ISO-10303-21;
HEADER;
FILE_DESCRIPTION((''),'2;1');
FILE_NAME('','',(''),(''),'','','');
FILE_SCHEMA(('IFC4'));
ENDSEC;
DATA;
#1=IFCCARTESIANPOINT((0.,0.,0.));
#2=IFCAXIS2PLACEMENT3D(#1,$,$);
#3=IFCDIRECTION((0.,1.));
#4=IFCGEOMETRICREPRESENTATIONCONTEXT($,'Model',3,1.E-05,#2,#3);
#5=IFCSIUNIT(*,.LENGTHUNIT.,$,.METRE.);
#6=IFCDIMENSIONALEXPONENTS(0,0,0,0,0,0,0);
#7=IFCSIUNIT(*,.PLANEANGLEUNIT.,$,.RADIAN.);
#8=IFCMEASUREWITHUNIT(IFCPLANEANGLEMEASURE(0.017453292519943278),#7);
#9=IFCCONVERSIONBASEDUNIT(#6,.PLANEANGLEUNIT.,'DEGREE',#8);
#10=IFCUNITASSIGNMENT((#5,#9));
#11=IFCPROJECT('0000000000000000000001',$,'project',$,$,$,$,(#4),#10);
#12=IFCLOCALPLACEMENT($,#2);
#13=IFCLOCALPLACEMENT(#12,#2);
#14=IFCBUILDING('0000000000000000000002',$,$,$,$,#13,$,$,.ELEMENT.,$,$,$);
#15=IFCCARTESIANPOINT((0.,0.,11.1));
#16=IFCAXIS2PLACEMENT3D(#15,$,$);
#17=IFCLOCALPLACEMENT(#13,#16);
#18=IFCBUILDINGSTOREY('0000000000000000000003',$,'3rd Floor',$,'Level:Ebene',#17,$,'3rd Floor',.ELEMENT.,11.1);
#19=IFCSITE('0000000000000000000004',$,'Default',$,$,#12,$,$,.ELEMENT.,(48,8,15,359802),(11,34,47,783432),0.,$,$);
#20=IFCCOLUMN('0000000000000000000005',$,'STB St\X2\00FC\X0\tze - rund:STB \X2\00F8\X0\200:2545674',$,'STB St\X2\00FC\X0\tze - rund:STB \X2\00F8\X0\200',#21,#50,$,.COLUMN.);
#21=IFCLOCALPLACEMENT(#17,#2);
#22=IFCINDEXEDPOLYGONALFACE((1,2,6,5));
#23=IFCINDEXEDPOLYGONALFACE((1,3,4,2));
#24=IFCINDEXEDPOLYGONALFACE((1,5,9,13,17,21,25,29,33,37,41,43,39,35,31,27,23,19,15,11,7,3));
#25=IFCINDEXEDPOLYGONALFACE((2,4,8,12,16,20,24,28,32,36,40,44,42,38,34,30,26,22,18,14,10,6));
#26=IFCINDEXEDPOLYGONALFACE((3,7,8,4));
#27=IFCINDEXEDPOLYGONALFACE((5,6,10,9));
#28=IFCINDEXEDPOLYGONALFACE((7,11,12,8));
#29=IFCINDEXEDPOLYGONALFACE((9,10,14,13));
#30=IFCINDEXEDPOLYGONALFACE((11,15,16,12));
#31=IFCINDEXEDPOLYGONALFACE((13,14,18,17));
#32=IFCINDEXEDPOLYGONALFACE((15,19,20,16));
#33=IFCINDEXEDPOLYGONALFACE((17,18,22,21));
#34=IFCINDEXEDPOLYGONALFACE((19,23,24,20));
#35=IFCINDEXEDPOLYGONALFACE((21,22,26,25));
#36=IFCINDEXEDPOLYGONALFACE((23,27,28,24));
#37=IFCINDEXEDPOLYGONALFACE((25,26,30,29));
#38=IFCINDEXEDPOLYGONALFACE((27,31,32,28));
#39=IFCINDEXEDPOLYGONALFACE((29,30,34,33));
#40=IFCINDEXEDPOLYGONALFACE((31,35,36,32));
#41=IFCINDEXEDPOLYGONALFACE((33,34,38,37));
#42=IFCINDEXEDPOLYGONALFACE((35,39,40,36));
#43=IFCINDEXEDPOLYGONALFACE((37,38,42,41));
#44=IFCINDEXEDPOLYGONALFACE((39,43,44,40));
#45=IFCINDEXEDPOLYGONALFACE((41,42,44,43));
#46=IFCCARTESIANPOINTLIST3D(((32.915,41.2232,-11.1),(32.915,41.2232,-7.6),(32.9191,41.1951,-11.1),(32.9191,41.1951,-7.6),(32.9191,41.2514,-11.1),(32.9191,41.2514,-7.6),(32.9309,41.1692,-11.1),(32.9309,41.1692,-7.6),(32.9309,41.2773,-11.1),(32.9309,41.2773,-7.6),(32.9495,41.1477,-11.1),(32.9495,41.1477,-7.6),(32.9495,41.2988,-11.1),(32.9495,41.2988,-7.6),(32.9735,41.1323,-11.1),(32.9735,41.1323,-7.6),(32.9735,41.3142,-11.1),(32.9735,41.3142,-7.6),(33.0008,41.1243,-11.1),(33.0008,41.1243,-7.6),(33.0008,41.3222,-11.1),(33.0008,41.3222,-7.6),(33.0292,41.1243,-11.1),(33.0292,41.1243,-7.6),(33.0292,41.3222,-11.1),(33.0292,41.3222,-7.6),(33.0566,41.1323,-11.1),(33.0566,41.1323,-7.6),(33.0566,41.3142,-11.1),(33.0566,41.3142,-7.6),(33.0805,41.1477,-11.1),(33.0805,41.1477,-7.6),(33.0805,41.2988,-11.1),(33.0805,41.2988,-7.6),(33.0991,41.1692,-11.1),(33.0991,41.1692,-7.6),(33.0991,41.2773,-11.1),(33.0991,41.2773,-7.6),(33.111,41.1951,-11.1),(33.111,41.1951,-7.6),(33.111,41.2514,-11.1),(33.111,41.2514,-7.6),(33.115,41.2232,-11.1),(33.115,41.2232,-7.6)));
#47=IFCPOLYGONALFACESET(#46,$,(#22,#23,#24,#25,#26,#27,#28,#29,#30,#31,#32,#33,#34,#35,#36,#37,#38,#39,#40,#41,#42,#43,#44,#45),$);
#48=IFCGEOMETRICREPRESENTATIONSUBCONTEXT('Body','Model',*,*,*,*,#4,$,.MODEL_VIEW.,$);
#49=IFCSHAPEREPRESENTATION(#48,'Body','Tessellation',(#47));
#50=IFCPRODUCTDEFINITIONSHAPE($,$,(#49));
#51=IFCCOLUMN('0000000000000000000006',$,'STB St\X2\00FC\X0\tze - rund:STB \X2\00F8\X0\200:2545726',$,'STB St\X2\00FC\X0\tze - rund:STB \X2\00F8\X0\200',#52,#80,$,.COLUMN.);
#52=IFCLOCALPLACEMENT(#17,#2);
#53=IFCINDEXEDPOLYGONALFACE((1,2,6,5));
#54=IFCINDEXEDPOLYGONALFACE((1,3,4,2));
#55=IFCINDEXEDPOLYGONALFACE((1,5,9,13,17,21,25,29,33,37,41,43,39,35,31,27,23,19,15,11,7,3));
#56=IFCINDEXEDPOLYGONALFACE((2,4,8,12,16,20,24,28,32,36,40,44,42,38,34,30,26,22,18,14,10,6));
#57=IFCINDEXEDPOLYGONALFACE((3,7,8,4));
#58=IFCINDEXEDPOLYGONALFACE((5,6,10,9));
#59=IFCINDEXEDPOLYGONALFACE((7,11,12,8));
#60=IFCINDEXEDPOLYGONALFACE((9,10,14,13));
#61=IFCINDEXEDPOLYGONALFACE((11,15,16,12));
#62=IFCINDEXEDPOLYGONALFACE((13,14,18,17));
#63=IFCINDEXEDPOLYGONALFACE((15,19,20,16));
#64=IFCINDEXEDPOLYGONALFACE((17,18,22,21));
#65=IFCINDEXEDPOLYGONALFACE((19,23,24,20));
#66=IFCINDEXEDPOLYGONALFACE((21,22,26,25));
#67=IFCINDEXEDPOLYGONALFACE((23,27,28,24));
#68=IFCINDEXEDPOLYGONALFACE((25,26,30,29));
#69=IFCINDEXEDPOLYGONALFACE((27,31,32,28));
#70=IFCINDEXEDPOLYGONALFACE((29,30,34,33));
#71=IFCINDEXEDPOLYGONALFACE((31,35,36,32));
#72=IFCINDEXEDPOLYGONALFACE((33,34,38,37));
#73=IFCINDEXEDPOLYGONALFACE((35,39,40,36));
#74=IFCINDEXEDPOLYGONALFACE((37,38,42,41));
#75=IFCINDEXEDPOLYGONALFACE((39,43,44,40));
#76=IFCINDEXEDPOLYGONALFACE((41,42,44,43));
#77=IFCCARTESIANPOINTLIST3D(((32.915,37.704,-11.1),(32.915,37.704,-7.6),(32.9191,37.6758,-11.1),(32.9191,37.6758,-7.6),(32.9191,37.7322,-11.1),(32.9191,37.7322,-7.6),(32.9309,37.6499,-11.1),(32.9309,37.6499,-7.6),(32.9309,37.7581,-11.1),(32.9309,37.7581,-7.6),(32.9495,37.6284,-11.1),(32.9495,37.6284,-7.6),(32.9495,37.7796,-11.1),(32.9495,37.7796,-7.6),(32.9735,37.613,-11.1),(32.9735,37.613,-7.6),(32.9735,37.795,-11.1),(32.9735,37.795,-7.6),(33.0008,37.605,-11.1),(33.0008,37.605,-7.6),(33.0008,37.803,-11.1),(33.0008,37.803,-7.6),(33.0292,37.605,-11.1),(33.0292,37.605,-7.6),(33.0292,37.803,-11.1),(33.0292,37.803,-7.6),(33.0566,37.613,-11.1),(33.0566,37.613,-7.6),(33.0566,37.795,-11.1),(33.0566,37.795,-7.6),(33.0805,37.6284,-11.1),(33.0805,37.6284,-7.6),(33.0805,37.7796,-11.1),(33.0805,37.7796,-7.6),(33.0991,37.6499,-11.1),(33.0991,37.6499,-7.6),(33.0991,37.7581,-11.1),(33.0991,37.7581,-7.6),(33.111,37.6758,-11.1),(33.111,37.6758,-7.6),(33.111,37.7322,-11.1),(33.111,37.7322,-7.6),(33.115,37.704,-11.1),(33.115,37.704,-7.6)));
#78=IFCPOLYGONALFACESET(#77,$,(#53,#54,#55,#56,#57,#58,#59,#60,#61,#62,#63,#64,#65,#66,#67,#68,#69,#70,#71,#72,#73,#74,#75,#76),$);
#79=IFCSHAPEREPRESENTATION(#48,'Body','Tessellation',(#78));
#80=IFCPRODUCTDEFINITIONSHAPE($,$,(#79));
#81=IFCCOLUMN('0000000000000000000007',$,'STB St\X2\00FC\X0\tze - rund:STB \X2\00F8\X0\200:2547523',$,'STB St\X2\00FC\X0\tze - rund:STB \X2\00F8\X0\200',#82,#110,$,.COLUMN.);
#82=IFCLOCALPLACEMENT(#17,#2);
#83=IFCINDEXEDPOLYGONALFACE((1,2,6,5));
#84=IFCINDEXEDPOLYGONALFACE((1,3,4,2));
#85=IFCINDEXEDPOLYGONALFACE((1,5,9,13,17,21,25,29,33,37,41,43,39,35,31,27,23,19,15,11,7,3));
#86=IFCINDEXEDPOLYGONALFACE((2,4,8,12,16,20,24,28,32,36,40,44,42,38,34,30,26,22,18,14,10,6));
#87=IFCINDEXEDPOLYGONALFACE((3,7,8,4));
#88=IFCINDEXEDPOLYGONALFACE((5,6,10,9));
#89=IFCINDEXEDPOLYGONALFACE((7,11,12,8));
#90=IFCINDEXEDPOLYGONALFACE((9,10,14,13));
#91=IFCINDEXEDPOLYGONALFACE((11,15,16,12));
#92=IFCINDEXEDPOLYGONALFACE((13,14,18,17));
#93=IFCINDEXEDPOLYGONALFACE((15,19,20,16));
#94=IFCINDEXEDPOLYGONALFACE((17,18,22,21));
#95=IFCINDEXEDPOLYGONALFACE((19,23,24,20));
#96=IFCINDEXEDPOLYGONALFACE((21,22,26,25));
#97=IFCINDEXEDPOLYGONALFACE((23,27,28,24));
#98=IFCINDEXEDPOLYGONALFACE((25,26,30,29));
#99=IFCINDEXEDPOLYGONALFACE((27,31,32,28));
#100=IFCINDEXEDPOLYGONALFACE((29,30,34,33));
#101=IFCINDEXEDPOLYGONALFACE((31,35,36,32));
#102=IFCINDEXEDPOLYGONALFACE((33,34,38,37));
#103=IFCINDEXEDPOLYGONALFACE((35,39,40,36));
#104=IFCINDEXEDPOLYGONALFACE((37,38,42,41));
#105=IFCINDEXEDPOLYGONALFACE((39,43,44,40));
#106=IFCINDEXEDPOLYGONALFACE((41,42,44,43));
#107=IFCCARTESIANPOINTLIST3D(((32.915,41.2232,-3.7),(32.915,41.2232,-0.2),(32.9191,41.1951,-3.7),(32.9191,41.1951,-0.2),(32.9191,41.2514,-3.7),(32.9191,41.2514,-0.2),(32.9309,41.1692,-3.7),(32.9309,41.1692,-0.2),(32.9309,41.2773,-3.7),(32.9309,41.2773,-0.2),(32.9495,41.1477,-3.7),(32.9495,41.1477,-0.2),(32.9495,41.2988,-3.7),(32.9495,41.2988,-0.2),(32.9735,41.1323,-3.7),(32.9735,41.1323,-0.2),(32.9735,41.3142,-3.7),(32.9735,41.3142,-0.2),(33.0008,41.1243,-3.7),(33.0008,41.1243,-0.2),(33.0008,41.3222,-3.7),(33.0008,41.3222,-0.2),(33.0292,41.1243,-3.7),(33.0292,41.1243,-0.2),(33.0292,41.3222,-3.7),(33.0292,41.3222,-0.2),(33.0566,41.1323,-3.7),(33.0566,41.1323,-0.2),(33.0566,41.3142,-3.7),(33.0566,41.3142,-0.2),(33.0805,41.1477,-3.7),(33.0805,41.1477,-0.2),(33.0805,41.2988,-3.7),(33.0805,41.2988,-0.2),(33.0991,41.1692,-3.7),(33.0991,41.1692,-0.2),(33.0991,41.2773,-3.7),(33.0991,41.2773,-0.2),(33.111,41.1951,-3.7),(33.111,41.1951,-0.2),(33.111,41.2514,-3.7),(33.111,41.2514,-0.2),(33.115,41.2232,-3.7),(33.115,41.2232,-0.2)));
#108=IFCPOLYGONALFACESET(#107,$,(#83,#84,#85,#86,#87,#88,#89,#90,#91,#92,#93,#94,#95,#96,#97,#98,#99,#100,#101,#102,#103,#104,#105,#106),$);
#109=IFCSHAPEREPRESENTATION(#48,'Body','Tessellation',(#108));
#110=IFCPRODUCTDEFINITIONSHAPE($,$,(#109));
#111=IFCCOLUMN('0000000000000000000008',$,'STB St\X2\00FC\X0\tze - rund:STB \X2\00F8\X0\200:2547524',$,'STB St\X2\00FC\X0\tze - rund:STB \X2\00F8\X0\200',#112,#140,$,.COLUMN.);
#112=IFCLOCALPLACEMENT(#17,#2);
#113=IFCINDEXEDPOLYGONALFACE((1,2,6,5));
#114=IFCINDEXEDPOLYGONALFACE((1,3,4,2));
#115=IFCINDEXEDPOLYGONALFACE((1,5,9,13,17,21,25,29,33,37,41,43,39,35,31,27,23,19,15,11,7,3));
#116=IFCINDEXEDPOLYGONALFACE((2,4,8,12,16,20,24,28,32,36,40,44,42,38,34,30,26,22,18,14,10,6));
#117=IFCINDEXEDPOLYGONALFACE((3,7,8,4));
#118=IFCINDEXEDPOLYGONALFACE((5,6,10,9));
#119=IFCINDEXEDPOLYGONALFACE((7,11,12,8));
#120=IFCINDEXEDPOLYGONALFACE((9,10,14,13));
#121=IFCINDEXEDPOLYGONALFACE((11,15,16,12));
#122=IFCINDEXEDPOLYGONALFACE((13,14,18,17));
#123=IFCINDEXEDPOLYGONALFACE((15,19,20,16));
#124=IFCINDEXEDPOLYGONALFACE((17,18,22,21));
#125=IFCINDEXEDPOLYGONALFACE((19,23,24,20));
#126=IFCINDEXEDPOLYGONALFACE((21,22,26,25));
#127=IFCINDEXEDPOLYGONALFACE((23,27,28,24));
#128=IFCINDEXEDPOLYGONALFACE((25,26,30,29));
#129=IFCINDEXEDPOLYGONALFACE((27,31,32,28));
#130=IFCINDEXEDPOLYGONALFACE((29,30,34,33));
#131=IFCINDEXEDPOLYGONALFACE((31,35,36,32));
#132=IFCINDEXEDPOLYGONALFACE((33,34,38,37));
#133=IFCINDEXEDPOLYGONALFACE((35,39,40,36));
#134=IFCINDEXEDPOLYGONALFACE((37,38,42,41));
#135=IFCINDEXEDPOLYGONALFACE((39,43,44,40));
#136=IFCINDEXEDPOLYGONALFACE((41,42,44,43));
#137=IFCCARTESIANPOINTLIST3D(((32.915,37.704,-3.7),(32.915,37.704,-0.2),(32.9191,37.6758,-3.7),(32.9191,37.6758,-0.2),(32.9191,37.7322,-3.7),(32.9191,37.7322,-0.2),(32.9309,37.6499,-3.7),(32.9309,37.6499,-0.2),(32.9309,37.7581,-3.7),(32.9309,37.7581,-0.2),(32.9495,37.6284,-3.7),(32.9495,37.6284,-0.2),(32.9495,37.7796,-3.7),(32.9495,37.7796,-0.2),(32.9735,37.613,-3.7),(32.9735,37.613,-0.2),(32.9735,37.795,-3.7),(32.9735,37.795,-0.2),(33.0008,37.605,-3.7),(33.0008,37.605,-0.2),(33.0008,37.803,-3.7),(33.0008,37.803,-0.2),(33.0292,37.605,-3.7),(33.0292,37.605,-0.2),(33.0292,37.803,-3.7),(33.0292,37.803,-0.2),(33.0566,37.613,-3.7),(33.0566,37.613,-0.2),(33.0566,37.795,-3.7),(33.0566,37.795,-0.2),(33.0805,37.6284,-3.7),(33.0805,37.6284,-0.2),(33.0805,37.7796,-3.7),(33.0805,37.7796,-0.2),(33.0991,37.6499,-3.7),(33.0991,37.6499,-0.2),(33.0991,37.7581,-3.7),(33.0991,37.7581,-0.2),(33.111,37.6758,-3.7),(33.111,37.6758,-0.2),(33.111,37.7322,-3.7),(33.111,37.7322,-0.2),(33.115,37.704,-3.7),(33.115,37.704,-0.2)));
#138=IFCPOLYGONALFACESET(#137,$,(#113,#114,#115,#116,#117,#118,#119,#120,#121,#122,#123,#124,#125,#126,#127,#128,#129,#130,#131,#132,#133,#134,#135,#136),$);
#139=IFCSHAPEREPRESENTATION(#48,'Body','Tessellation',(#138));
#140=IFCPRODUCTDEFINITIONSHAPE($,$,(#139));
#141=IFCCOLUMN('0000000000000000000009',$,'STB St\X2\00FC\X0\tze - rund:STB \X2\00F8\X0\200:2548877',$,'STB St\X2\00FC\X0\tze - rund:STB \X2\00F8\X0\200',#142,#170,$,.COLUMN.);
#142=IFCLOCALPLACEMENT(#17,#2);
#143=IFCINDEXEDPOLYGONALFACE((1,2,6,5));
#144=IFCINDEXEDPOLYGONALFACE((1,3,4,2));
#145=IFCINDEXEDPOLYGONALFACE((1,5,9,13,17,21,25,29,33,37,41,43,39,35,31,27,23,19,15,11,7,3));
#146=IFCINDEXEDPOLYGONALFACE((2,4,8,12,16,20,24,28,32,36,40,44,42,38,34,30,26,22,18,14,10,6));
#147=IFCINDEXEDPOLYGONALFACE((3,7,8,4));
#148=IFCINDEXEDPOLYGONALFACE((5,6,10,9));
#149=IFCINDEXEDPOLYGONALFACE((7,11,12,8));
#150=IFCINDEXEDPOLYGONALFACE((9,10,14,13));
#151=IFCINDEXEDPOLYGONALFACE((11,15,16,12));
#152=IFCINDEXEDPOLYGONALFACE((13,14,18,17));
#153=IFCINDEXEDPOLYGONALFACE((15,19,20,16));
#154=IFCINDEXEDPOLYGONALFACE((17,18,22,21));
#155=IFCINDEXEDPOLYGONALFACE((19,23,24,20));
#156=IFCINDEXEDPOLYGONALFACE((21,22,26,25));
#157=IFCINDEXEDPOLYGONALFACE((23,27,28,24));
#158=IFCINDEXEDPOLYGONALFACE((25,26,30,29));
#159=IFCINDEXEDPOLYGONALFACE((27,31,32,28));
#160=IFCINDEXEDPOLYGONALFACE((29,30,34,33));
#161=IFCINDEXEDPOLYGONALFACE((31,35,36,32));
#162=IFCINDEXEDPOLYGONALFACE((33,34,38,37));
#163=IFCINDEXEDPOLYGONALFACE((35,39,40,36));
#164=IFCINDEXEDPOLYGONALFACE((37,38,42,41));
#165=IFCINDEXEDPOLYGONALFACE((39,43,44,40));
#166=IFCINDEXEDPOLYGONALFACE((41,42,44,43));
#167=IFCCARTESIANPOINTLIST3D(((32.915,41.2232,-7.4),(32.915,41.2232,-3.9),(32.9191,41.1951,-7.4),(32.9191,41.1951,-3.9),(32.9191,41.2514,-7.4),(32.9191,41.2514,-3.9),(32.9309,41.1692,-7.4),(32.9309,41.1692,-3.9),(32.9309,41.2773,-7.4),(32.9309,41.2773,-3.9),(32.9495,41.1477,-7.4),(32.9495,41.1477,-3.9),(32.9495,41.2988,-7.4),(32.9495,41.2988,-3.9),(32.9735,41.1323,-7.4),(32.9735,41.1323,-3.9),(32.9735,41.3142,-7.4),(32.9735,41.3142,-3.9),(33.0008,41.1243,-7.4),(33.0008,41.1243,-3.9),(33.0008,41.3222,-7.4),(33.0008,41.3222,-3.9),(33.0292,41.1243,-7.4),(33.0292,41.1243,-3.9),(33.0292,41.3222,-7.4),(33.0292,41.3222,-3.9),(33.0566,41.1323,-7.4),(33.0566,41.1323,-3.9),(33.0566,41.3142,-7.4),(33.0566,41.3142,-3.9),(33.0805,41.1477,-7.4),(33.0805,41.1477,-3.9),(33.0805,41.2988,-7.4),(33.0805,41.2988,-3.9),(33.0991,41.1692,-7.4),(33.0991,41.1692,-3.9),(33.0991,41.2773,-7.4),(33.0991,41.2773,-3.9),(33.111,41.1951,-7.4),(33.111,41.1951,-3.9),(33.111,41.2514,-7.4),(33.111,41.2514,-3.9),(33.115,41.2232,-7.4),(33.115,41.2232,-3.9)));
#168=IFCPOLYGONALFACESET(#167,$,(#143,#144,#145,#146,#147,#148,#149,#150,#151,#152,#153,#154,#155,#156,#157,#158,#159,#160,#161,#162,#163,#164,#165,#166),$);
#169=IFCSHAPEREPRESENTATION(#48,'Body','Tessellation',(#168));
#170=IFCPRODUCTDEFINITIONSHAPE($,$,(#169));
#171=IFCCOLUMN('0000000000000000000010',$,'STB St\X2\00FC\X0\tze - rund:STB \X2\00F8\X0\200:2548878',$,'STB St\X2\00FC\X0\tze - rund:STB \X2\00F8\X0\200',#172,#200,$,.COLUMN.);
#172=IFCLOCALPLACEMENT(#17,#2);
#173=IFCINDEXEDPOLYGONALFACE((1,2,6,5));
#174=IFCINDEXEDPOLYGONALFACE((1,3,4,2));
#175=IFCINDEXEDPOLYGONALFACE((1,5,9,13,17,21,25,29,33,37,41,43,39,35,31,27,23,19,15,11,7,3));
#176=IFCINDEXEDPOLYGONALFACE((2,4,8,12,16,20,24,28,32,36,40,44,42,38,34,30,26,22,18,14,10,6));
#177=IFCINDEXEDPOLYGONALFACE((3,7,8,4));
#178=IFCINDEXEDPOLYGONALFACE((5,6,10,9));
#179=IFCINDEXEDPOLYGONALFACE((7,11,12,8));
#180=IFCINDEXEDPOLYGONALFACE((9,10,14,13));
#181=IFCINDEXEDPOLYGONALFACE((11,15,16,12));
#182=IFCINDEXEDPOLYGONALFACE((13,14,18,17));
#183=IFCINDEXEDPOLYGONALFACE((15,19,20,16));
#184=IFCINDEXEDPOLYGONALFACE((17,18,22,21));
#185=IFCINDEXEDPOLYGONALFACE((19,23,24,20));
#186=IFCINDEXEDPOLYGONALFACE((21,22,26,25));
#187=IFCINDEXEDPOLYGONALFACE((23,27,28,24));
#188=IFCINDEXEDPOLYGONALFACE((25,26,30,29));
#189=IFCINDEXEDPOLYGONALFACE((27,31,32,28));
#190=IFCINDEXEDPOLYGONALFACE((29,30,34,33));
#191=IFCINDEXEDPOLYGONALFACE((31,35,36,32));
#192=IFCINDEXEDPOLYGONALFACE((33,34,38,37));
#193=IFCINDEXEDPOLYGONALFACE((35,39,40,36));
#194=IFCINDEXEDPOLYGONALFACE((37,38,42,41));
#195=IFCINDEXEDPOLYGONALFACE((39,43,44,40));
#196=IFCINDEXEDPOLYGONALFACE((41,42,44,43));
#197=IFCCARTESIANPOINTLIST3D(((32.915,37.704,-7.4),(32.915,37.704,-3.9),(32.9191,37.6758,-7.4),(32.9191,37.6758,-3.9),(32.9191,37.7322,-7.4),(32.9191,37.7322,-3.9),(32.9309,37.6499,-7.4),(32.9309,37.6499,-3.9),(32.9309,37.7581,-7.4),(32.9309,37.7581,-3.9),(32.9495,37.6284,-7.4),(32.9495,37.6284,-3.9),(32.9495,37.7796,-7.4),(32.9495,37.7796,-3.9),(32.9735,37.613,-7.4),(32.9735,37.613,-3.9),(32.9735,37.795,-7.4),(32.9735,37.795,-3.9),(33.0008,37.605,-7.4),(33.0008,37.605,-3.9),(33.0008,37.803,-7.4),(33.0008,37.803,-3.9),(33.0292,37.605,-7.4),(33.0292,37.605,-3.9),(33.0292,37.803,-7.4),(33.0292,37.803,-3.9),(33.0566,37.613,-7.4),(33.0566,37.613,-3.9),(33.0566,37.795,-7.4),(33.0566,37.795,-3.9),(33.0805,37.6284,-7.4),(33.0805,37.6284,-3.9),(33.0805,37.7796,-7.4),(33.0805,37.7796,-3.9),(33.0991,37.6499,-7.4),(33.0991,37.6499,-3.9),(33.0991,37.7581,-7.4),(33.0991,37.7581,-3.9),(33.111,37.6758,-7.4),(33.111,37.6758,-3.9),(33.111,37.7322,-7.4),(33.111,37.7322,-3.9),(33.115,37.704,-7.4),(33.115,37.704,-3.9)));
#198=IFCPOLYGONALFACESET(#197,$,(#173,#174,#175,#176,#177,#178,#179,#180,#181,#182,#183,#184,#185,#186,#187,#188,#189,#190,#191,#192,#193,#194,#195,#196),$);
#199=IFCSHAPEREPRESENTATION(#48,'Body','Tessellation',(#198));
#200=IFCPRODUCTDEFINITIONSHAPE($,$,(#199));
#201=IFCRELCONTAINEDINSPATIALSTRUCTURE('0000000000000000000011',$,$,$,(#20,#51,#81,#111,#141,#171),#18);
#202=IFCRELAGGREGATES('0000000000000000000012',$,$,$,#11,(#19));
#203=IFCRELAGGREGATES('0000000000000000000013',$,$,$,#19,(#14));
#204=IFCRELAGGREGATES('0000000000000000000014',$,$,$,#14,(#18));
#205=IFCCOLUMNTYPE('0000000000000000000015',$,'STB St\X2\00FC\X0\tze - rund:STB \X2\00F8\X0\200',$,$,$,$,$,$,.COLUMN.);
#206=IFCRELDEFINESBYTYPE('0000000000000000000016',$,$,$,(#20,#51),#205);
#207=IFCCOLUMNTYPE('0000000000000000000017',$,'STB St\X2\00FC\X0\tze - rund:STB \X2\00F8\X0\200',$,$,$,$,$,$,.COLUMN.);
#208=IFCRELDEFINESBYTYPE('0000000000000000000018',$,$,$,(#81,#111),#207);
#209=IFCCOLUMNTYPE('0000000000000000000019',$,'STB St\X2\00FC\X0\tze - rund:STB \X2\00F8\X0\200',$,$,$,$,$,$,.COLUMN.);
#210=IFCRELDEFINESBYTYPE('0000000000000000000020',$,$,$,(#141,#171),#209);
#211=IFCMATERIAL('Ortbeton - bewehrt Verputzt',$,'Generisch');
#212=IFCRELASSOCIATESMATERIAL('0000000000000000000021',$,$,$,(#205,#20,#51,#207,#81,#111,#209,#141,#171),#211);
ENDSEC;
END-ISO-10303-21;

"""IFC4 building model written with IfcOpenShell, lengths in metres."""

from ifc_helpers import new_model, entity, si_unit, converted_unit, direction, frame, origin, place, context, subcontext, project, spatial, arc, indexed_curve, outline, extrude, source, transform, mapped, material, type_object, type_shapes, element, save


model = new_model("IFC4")

# Units and contexts
model_context = context("Model", 3, precision=1e-05, world=origin(), true_north=direction((0.0, 1.0)))
body_context = subcontext(model_context, "Body", "Model", "MODEL_VIEW")
ifc_project = project(units=[si_unit("LENGTHUNIT", "METRE"), converted_unit("PLANEANGLEUNIT", "DEGREE", entity("IfcPlaneAngleMeasure", 0.017453292519943278), si_unit("PLANEANGLEUNIT", "RADIAN"), dimensions=[0, 0, 0, 0, 0, 0, 0])], contexts=[model_context])

# Site, building, storey
site_placement = place(None, origin())
site = spatial("IfcSite", under=ifc_project, at=site_placement, Name="Default", CompositionType="ELEMENT", RefLatitude=(48, 8, 15, 359802), RefLongitude=(11, 34, 47, 783432), RefElevation=0.0)
building_placement = place(site_placement, origin())
building = spatial("IfcBuilding", under=site, at=building_placement, CompositionType="ELEMENT")
storey_placement = place(building_placement, frame((0.0, 0.0, 11.1)))
storey = spatial("IfcBuildingStorey", under=building, at=storey_placement, Name="3rd Floor", ObjectType="Level:Ebene", LongName="3rd Floor", CompositionType="ELEMENT", Elevation=11.1)

# Columns
ifc_material_1 = material(Name="Ortbeton - bewehrt Verputzt", Category="Generisch")
column_type_1 = type_object("IfcColumnType", Name="STB Stütze - rund:STB ø200", PredefinedType="COLUMN", material=ifc_material_1)
shared_shape_1 = source(origin(), body_context, "Body", "SweptSolid", [
    extrude(outline(indexed_curve([(-0.1, 0.0), (0.0, -0.1), (0.1, 0.0), (0.0, 0.1)], segments=[arc(1, 2, 3), arc(3, 4, 1)], self_intersect=False)), origin(), (0.0, 0.0, 1.0), 3.5),
])
type_shapes(column_type_1, [shared_shape_1])
for number, where, name in (
    (1, (33.015, 41.2232, -11.1), "STB Stütze - rund:STB ø200:2545674"),
    (2, (33.015, 37.704, -11.1), "STB Stütze - rund:STB ø200:2545726"),
):
    element("IfcColumn", number, at=place(storey_placement, frame(where)), inside=storey, type_object=column_type_1, material=ifc_material_1, Name=name, ObjectType="STB Stütze - rund:STB ø200", PredefinedType="COLUMN", context=body_context, shape_type="MappedRepresentation", body=[
        mapped(shared_shape_1, transform((0.0, 0.0, 0.0), scale=1.0)),
    ])
column_type_2 = type_object("IfcColumnType", Name="STB Stütze - rund:STB ø200", PredefinedType="COLUMN", material=ifc_material_1)
shared_shape_2 = source(origin(), body_context, "Body", "SweptSolid", [
    extrude(outline(indexed_curve([(-0.1, 0.0), (0.0, -0.1), (0.1, 0.0), (0.0, 0.1)], segments=[arc(1, 2, 3), arc(3, 4, 1)], self_intersect=False)), frame((0.0, 0.0, 7.4)), (0.0, 0.0, 1.0), 3.5),
])
type_shapes(column_type_2, [shared_shape_2])
for number, where, name in (
    (3, (33.015, 41.2232, -11.1), "STB Stütze - rund:STB ø200:2547523"),
    (4, (33.015, 37.704, -11.1), "STB Stütze - rund:STB ø200:2547524"),
):
    element("IfcColumn", number, at=place(storey_placement, frame(where)), inside=storey, type_object=column_type_2, material=ifc_material_1, Name=name, ObjectType="STB Stütze - rund:STB ø200", PredefinedType="COLUMN", context=body_context, shape_type="MappedRepresentation", body=[
        mapped(shared_shape_2, transform((0.0, 0.0, 0.0), scale=1.0)),
    ])
column_type_3 = type_object("IfcColumnType", Name="STB Stütze - rund:STB ø200", PredefinedType="COLUMN", material=ifc_material_1)
shared_shape_3 = source(origin(), body_context, "Body", "SweptSolid", [
    extrude(outline(indexed_curve([(-0.1, 0.0), (0.0, -0.1), (0.1, 0.0), (0.0, 0.1)], segments=[arc(1, 2, 3), arc(3, 4, 1)], self_intersect=False)), frame((0.0, 0.0, 3.7)), (0.0, 0.0, 1.0), 3.5),
])
type_shapes(column_type_3, [shared_shape_3])
for number, where, name in (
    (5, (33.015, 41.2232, -11.1), "STB Stütze - rund:STB ø200:2548877"),
    (6, (33.015, 37.704, -11.1), "STB Stütze - rund:STB ø200:2548878"),
):
    element("IfcColumn", number, at=place(storey_placement, frame(where)), inside=storey, type_object=column_type_3, material=ifc_material_1, Name=name, ObjectType="STB Stütze - rund:STB ø200", PredefinedType="COLUMN", context=body_context, shape_type="MappedRepresentation", body=[
        mapped(shared_shape_3, transform((0.0, 0.0, 0.0), scale=1.0)),
    ])

save(model, "model.ifc")
